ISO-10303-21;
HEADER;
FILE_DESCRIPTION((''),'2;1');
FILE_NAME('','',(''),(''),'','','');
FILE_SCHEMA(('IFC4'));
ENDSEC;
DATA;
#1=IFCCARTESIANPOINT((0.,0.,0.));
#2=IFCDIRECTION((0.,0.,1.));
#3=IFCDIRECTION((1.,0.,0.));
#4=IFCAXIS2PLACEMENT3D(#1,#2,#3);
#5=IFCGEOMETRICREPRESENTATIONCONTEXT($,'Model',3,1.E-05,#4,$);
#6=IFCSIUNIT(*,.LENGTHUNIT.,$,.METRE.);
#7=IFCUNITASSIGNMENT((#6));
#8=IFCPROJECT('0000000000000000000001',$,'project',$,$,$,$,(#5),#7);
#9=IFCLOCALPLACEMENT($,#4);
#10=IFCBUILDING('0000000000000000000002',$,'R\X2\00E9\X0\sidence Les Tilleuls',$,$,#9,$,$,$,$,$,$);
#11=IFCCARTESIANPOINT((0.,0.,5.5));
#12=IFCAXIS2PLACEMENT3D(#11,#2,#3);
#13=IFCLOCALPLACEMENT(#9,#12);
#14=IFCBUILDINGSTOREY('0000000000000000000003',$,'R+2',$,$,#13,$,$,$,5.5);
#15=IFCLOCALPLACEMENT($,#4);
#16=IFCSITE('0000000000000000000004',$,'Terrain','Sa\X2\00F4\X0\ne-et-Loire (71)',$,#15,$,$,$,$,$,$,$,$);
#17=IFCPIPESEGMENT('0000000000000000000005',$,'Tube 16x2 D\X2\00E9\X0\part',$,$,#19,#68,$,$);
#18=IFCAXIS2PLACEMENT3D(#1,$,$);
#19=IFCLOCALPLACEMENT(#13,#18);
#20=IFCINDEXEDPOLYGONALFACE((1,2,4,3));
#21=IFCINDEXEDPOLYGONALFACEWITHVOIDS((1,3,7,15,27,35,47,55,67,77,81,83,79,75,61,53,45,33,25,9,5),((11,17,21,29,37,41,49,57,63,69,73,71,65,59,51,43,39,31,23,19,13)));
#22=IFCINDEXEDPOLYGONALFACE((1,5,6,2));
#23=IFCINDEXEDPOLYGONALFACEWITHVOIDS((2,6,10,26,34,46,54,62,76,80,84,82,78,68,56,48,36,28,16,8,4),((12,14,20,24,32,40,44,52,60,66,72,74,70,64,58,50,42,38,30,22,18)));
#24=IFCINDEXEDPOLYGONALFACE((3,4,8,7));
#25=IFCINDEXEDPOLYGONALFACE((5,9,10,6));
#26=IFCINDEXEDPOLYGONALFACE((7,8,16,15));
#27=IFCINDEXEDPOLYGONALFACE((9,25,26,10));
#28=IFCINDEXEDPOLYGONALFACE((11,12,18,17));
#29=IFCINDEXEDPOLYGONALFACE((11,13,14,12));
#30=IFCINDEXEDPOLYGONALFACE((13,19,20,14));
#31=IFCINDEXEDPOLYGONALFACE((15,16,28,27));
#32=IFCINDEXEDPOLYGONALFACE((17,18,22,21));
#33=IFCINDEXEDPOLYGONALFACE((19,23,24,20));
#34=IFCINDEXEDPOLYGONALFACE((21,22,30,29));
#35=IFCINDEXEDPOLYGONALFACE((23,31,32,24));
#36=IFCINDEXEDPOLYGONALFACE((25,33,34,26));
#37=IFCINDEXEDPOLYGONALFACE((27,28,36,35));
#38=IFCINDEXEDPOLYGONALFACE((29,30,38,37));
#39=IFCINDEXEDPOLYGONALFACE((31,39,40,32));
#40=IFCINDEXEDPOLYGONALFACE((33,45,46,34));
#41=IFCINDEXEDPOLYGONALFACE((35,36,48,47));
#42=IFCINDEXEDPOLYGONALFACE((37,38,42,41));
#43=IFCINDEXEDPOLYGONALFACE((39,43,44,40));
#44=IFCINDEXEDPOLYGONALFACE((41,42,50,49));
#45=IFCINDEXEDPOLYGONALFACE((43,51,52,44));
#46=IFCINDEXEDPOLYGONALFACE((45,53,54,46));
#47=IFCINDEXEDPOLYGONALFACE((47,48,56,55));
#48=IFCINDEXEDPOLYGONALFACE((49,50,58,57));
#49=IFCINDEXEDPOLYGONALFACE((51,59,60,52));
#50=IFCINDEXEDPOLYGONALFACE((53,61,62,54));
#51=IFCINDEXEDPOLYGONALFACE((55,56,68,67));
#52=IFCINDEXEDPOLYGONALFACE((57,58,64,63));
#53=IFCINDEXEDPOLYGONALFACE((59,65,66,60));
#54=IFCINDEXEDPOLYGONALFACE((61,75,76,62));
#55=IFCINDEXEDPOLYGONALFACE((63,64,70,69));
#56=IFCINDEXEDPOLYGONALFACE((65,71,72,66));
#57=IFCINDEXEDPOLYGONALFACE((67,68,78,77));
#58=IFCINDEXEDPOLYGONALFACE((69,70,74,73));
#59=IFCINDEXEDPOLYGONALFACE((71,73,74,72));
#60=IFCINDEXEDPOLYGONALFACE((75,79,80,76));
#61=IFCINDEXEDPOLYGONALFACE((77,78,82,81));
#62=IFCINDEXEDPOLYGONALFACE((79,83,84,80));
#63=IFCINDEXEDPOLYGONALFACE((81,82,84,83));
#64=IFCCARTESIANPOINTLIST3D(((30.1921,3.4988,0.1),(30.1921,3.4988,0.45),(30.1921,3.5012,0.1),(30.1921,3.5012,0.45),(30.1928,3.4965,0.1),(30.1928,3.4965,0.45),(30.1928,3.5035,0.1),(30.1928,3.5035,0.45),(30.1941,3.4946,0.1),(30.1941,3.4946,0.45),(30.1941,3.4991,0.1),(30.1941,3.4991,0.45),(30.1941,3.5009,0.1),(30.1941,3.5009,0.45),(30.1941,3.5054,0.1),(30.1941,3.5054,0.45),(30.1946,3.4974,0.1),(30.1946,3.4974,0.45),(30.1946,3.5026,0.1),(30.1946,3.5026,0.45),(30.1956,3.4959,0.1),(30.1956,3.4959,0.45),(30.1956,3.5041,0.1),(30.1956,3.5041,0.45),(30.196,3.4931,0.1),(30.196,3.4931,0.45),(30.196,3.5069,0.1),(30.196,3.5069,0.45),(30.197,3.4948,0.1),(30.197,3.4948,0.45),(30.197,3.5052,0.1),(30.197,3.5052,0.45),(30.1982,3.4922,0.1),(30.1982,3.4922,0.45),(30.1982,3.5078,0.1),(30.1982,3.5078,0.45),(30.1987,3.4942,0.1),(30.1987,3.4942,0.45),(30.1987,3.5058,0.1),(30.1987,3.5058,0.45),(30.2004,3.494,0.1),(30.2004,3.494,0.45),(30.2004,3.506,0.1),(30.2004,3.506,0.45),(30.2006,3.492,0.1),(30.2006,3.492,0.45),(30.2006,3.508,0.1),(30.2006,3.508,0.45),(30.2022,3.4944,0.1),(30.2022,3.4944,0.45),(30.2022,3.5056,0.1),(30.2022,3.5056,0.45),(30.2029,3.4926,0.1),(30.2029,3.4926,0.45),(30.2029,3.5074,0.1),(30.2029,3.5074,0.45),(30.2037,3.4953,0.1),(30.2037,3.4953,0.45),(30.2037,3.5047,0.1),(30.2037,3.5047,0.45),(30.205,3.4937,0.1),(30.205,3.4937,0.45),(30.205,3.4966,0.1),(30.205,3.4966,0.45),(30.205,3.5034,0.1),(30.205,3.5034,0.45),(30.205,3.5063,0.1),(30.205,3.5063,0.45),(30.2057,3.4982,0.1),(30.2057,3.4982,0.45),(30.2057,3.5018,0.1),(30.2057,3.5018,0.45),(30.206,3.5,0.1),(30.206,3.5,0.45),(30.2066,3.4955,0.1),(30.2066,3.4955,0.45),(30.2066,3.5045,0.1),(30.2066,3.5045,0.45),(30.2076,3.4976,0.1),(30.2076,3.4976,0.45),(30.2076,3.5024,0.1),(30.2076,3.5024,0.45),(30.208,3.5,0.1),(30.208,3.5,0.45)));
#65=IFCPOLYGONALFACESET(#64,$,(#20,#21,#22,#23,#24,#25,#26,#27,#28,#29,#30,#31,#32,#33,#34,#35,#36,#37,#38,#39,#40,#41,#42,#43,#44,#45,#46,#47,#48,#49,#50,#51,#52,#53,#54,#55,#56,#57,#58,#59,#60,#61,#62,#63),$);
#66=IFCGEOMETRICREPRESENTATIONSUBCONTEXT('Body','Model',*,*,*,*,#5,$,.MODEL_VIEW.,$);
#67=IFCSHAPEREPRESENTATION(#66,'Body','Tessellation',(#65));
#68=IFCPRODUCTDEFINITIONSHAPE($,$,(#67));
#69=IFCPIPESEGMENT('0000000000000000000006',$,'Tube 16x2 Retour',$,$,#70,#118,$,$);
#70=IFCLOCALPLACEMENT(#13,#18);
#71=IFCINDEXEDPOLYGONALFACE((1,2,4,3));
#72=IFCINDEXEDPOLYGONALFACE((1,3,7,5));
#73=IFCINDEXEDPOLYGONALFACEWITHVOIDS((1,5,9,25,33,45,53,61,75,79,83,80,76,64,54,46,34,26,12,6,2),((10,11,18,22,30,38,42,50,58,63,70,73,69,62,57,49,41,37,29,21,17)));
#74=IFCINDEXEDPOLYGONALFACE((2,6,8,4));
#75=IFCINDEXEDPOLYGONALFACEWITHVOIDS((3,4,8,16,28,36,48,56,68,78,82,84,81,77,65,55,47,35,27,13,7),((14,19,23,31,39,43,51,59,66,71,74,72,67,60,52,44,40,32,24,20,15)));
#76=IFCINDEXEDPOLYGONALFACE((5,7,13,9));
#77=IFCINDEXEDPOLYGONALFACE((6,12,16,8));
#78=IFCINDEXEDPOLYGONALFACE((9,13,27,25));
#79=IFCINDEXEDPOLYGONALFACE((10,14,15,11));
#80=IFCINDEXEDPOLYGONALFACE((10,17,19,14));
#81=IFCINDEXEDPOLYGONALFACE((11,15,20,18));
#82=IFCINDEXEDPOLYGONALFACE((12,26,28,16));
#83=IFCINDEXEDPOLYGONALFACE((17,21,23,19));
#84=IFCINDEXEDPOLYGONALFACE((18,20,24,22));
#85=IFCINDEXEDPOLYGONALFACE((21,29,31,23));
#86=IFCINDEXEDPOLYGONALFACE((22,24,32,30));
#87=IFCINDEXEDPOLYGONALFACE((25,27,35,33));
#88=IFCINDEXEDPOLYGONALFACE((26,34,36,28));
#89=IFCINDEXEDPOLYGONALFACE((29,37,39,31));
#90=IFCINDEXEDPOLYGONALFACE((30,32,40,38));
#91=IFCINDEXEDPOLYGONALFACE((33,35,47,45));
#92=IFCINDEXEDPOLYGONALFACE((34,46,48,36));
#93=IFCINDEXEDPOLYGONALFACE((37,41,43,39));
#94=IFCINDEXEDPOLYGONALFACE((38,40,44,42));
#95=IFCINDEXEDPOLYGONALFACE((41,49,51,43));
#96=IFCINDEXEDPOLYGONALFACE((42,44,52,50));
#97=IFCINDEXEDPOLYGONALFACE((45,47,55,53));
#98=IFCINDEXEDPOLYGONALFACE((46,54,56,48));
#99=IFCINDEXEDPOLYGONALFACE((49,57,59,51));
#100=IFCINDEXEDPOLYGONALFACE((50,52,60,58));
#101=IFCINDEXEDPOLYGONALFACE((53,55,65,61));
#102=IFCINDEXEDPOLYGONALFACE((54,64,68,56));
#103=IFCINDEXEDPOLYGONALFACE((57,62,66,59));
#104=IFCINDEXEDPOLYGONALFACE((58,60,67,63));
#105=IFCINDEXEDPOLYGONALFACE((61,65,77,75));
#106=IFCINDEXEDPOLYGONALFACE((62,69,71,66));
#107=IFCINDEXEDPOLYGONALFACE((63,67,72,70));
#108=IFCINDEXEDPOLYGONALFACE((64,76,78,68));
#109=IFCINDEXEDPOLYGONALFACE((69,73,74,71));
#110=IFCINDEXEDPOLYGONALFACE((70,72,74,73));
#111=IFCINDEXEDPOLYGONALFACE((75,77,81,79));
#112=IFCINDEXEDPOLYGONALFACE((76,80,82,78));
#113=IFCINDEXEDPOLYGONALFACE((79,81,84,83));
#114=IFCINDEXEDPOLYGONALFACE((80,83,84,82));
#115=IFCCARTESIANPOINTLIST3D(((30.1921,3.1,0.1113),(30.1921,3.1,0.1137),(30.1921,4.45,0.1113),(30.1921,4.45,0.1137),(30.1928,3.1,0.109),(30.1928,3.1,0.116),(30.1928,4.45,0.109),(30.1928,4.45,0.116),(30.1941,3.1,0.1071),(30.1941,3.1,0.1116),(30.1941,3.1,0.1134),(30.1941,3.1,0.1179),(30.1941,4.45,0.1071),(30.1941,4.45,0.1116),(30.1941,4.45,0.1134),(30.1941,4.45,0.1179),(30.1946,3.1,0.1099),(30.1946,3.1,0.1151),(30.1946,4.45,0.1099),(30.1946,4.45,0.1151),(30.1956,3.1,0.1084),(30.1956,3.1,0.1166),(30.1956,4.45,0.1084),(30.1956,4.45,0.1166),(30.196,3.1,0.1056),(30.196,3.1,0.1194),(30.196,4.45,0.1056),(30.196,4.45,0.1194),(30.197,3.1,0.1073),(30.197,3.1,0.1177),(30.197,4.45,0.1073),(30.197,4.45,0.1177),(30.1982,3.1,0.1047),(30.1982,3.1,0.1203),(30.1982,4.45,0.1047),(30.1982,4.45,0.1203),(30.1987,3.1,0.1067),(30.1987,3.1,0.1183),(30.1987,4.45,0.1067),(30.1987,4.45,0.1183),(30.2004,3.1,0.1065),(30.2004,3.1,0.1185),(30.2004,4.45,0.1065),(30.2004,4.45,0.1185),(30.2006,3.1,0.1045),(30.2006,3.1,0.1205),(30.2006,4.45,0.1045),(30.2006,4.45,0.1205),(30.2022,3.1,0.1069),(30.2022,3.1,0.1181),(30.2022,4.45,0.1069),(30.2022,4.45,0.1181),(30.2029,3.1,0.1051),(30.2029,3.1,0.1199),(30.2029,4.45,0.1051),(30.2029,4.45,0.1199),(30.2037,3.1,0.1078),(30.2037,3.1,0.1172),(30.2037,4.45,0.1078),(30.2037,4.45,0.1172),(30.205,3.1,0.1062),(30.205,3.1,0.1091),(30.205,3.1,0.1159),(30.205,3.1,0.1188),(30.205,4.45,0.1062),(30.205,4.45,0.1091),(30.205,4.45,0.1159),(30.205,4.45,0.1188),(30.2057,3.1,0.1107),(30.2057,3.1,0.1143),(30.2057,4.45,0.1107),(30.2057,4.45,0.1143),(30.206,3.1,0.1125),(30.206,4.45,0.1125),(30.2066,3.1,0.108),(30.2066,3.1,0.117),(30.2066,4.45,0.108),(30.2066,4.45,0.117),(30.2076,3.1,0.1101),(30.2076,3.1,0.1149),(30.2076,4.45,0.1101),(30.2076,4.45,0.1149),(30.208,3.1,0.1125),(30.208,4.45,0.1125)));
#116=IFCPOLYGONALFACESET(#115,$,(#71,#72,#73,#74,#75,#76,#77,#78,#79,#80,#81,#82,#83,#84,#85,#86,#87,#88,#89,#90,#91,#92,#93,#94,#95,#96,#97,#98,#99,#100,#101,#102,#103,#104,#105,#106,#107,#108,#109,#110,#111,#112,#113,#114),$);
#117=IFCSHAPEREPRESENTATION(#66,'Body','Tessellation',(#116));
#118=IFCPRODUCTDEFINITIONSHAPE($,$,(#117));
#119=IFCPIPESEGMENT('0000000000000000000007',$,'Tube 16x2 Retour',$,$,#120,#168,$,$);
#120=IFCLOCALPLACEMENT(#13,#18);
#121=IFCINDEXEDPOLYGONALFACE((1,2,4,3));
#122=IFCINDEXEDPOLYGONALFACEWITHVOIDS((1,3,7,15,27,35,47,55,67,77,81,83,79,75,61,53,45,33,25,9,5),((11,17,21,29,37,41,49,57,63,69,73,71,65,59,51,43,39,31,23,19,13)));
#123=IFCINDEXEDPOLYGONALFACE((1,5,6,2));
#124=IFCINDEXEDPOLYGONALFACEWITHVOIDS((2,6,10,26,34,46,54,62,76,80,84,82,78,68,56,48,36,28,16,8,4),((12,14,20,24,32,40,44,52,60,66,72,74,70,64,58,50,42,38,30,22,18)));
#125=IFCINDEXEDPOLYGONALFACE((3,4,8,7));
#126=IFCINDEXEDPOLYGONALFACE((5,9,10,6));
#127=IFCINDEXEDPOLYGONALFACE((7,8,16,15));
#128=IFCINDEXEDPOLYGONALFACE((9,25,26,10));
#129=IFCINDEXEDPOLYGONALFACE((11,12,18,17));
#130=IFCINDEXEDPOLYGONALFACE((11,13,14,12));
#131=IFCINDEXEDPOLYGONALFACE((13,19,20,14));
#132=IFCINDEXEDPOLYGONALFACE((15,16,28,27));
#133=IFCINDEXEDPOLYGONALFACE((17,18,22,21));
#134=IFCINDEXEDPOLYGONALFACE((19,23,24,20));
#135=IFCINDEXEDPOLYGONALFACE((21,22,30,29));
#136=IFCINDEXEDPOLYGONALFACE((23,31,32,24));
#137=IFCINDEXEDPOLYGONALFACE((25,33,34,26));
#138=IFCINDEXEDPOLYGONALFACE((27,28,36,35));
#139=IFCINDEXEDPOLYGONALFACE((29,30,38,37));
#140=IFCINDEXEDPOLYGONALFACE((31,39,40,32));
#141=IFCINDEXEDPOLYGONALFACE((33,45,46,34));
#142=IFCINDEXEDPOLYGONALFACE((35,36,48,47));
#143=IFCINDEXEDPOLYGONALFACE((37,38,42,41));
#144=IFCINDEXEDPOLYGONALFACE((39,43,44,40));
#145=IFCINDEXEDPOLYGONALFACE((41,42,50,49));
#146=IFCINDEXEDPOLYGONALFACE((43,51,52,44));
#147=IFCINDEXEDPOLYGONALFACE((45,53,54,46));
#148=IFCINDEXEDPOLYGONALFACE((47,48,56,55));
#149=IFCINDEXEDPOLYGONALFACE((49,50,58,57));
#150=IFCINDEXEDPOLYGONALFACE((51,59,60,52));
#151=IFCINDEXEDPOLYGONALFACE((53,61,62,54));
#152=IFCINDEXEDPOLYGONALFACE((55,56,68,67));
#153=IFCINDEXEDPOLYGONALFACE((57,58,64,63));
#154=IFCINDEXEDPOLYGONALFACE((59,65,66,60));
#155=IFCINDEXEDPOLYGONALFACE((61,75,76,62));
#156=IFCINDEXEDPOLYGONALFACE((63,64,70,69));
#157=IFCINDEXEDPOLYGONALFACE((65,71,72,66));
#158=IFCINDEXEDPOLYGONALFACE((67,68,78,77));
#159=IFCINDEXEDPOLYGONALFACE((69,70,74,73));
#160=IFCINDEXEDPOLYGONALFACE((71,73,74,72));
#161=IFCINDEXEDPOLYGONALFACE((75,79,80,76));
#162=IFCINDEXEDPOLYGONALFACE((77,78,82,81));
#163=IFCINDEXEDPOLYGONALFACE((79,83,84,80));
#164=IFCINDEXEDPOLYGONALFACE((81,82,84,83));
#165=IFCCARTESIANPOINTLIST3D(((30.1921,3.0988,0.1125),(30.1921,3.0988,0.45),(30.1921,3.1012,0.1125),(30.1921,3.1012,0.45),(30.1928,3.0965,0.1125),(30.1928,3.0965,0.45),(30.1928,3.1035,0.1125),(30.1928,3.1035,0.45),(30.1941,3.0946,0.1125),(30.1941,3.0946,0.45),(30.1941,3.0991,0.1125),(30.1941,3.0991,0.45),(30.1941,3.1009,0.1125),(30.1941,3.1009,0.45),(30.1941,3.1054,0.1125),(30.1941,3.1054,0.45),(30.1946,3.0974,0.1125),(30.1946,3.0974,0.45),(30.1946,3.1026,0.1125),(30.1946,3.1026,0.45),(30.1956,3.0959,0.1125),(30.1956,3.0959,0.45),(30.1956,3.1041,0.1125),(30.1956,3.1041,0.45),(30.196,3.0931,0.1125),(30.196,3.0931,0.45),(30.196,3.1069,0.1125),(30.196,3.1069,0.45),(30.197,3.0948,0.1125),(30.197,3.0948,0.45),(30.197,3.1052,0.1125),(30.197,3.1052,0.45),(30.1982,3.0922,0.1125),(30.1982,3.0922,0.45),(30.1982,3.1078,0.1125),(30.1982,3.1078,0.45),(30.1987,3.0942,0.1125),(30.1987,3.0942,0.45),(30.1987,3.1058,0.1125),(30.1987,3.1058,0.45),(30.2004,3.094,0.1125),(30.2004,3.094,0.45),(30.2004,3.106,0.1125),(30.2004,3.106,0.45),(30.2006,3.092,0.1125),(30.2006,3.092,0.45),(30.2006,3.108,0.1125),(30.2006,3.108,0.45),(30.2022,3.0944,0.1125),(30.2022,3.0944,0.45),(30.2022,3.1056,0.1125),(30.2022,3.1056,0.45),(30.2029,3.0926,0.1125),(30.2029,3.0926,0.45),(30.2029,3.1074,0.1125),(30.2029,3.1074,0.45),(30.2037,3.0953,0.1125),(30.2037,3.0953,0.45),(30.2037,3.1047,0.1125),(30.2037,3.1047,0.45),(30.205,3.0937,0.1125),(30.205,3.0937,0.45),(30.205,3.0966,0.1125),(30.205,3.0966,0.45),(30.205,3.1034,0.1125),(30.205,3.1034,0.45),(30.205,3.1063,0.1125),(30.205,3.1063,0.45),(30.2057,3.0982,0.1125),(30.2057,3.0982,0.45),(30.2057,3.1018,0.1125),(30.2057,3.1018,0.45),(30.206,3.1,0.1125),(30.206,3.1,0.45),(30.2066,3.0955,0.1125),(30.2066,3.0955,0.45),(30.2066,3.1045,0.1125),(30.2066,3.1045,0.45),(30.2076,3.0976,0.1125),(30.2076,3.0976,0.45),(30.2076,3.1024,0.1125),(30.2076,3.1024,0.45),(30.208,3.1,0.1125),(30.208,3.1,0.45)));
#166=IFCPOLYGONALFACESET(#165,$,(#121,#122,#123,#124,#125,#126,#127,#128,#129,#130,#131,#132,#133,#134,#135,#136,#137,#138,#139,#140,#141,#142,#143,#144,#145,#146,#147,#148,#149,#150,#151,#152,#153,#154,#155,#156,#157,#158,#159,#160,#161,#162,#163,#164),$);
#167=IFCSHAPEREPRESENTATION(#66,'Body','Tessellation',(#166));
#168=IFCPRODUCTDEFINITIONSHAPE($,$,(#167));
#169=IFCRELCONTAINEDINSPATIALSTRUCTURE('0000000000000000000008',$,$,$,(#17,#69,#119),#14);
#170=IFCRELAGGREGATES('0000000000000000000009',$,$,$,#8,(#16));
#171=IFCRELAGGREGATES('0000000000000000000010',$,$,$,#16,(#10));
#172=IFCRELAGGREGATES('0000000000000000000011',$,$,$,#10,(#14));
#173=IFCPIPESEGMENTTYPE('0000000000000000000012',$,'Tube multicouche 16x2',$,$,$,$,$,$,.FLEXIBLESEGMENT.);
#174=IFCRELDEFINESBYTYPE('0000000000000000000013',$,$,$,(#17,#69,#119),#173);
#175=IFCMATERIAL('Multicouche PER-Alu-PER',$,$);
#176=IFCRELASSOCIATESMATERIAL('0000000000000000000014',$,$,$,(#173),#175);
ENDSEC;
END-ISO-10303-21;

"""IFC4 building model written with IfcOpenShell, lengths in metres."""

from ifc_helpers import new_model, si_unit, frame, origin_with_axes, place, context, subcontext, project, spatial, hollow_circle, extrude, material, type_object, element, save


model = new_model("IFC4")

# Units and contexts
model_context = context("Model", 3, precision=1e-05, world=origin_with_axes())
body_context = subcontext(model_context, "Body", "Model", "MODEL_VIEW")
ifc_project = project(units=[si_unit("LENGTHUNIT", "METRE")], contexts=[model_context])

# Site, building, storey
site_placement = place(None, origin_with_axes())
site = spatial("IfcSite", under=ifc_project, at=site_placement, Name="Terrain", Description="Saône-et-Loire (71)")
building_placement = place(None, origin_with_axes())
building = spatial("IfcBuilding", under=site, at=building_placement, Name="Résidence Les Tilleuls")
storey_placement = place(building_placement, frame((0.0, 0.0, 5.5), z_axis=(0.0, 0.0, 1.0), x_axis=(1.0, 0.0, 0.0)))
storey = spatial("IfcBuildingStorey", under=building, at=storey_placement, Name="R+2", Elevation=5.5)

# Pipe segments
ifc_material_1 = material(Name="Multicouche PER-Alu-PER")
pipe_segment_type_1 = type_object("IfcPipeSegmentType", Name="Tube multicouche 16x2", PredefinedType="FLEXIBLESEGMENT", material=ifc_material_1)
pipe_segment_1_placement = place(storey_placement, frame((30.2, 3.5, 0.1), z_axis=(0.0, 0.0, 1.0), x_axis=(1.0, 0.0, 0.0)))
element("IfcPipeSegment", 1, at=pipe_segment_1_placement, inside=storey, type_object=pipe_segment_type_1, Name="Tube 16x2 Départ", context=body_context, shape_type="SweptSolid", body=[
    extrude(hollow_circle(Radius=0.008, WallThickness=0.002), origin_with_axes(), (0.0, 0.0, 1.0), 0.35),
])
pipe_segment_2_placement = place(storey_placement, frame((30.2, 4.45, 0.1125), z_axis=(0.0, -1.0, 0.0), x_axis=(1.0, 0.0, 0.0)))
element("IfcPipeSegment", 2, at=pipe_segment_2_placement, inside=storey, type_object=pipe_segment_type_1, Name="Tube 16x2 Retour", context=body_context, shape_type="SweptSolid", body=[
    extrude(hollow_circle(Radius=0.008, WallThickness=0.002), origin_with_axes(), (0.0, 0.0, 1.0), 1.35),
])
pipe_segment_3_placement = place(storey_placement, frame((30.2, 3.1, 0.1125), z_axis=(0.0, 0.0, 1.0), x_axis=(1.0, 0.0, 0.0)))
element("IfcPipeSegment", 3, at=pipe_segment_3_placement, inside=storey, type_object=pipe_segment_type_1, Name="Tube 16x2 Retour", context=body_context, shape_type="SweptSolid", body=[
    extrude(hollow_circle(Radius=0.008, WallThickness=0.002), origin_with_axes(), (0.0, 0.0, 1.0), 0.3375),
])

save(model, "model.ifc")
